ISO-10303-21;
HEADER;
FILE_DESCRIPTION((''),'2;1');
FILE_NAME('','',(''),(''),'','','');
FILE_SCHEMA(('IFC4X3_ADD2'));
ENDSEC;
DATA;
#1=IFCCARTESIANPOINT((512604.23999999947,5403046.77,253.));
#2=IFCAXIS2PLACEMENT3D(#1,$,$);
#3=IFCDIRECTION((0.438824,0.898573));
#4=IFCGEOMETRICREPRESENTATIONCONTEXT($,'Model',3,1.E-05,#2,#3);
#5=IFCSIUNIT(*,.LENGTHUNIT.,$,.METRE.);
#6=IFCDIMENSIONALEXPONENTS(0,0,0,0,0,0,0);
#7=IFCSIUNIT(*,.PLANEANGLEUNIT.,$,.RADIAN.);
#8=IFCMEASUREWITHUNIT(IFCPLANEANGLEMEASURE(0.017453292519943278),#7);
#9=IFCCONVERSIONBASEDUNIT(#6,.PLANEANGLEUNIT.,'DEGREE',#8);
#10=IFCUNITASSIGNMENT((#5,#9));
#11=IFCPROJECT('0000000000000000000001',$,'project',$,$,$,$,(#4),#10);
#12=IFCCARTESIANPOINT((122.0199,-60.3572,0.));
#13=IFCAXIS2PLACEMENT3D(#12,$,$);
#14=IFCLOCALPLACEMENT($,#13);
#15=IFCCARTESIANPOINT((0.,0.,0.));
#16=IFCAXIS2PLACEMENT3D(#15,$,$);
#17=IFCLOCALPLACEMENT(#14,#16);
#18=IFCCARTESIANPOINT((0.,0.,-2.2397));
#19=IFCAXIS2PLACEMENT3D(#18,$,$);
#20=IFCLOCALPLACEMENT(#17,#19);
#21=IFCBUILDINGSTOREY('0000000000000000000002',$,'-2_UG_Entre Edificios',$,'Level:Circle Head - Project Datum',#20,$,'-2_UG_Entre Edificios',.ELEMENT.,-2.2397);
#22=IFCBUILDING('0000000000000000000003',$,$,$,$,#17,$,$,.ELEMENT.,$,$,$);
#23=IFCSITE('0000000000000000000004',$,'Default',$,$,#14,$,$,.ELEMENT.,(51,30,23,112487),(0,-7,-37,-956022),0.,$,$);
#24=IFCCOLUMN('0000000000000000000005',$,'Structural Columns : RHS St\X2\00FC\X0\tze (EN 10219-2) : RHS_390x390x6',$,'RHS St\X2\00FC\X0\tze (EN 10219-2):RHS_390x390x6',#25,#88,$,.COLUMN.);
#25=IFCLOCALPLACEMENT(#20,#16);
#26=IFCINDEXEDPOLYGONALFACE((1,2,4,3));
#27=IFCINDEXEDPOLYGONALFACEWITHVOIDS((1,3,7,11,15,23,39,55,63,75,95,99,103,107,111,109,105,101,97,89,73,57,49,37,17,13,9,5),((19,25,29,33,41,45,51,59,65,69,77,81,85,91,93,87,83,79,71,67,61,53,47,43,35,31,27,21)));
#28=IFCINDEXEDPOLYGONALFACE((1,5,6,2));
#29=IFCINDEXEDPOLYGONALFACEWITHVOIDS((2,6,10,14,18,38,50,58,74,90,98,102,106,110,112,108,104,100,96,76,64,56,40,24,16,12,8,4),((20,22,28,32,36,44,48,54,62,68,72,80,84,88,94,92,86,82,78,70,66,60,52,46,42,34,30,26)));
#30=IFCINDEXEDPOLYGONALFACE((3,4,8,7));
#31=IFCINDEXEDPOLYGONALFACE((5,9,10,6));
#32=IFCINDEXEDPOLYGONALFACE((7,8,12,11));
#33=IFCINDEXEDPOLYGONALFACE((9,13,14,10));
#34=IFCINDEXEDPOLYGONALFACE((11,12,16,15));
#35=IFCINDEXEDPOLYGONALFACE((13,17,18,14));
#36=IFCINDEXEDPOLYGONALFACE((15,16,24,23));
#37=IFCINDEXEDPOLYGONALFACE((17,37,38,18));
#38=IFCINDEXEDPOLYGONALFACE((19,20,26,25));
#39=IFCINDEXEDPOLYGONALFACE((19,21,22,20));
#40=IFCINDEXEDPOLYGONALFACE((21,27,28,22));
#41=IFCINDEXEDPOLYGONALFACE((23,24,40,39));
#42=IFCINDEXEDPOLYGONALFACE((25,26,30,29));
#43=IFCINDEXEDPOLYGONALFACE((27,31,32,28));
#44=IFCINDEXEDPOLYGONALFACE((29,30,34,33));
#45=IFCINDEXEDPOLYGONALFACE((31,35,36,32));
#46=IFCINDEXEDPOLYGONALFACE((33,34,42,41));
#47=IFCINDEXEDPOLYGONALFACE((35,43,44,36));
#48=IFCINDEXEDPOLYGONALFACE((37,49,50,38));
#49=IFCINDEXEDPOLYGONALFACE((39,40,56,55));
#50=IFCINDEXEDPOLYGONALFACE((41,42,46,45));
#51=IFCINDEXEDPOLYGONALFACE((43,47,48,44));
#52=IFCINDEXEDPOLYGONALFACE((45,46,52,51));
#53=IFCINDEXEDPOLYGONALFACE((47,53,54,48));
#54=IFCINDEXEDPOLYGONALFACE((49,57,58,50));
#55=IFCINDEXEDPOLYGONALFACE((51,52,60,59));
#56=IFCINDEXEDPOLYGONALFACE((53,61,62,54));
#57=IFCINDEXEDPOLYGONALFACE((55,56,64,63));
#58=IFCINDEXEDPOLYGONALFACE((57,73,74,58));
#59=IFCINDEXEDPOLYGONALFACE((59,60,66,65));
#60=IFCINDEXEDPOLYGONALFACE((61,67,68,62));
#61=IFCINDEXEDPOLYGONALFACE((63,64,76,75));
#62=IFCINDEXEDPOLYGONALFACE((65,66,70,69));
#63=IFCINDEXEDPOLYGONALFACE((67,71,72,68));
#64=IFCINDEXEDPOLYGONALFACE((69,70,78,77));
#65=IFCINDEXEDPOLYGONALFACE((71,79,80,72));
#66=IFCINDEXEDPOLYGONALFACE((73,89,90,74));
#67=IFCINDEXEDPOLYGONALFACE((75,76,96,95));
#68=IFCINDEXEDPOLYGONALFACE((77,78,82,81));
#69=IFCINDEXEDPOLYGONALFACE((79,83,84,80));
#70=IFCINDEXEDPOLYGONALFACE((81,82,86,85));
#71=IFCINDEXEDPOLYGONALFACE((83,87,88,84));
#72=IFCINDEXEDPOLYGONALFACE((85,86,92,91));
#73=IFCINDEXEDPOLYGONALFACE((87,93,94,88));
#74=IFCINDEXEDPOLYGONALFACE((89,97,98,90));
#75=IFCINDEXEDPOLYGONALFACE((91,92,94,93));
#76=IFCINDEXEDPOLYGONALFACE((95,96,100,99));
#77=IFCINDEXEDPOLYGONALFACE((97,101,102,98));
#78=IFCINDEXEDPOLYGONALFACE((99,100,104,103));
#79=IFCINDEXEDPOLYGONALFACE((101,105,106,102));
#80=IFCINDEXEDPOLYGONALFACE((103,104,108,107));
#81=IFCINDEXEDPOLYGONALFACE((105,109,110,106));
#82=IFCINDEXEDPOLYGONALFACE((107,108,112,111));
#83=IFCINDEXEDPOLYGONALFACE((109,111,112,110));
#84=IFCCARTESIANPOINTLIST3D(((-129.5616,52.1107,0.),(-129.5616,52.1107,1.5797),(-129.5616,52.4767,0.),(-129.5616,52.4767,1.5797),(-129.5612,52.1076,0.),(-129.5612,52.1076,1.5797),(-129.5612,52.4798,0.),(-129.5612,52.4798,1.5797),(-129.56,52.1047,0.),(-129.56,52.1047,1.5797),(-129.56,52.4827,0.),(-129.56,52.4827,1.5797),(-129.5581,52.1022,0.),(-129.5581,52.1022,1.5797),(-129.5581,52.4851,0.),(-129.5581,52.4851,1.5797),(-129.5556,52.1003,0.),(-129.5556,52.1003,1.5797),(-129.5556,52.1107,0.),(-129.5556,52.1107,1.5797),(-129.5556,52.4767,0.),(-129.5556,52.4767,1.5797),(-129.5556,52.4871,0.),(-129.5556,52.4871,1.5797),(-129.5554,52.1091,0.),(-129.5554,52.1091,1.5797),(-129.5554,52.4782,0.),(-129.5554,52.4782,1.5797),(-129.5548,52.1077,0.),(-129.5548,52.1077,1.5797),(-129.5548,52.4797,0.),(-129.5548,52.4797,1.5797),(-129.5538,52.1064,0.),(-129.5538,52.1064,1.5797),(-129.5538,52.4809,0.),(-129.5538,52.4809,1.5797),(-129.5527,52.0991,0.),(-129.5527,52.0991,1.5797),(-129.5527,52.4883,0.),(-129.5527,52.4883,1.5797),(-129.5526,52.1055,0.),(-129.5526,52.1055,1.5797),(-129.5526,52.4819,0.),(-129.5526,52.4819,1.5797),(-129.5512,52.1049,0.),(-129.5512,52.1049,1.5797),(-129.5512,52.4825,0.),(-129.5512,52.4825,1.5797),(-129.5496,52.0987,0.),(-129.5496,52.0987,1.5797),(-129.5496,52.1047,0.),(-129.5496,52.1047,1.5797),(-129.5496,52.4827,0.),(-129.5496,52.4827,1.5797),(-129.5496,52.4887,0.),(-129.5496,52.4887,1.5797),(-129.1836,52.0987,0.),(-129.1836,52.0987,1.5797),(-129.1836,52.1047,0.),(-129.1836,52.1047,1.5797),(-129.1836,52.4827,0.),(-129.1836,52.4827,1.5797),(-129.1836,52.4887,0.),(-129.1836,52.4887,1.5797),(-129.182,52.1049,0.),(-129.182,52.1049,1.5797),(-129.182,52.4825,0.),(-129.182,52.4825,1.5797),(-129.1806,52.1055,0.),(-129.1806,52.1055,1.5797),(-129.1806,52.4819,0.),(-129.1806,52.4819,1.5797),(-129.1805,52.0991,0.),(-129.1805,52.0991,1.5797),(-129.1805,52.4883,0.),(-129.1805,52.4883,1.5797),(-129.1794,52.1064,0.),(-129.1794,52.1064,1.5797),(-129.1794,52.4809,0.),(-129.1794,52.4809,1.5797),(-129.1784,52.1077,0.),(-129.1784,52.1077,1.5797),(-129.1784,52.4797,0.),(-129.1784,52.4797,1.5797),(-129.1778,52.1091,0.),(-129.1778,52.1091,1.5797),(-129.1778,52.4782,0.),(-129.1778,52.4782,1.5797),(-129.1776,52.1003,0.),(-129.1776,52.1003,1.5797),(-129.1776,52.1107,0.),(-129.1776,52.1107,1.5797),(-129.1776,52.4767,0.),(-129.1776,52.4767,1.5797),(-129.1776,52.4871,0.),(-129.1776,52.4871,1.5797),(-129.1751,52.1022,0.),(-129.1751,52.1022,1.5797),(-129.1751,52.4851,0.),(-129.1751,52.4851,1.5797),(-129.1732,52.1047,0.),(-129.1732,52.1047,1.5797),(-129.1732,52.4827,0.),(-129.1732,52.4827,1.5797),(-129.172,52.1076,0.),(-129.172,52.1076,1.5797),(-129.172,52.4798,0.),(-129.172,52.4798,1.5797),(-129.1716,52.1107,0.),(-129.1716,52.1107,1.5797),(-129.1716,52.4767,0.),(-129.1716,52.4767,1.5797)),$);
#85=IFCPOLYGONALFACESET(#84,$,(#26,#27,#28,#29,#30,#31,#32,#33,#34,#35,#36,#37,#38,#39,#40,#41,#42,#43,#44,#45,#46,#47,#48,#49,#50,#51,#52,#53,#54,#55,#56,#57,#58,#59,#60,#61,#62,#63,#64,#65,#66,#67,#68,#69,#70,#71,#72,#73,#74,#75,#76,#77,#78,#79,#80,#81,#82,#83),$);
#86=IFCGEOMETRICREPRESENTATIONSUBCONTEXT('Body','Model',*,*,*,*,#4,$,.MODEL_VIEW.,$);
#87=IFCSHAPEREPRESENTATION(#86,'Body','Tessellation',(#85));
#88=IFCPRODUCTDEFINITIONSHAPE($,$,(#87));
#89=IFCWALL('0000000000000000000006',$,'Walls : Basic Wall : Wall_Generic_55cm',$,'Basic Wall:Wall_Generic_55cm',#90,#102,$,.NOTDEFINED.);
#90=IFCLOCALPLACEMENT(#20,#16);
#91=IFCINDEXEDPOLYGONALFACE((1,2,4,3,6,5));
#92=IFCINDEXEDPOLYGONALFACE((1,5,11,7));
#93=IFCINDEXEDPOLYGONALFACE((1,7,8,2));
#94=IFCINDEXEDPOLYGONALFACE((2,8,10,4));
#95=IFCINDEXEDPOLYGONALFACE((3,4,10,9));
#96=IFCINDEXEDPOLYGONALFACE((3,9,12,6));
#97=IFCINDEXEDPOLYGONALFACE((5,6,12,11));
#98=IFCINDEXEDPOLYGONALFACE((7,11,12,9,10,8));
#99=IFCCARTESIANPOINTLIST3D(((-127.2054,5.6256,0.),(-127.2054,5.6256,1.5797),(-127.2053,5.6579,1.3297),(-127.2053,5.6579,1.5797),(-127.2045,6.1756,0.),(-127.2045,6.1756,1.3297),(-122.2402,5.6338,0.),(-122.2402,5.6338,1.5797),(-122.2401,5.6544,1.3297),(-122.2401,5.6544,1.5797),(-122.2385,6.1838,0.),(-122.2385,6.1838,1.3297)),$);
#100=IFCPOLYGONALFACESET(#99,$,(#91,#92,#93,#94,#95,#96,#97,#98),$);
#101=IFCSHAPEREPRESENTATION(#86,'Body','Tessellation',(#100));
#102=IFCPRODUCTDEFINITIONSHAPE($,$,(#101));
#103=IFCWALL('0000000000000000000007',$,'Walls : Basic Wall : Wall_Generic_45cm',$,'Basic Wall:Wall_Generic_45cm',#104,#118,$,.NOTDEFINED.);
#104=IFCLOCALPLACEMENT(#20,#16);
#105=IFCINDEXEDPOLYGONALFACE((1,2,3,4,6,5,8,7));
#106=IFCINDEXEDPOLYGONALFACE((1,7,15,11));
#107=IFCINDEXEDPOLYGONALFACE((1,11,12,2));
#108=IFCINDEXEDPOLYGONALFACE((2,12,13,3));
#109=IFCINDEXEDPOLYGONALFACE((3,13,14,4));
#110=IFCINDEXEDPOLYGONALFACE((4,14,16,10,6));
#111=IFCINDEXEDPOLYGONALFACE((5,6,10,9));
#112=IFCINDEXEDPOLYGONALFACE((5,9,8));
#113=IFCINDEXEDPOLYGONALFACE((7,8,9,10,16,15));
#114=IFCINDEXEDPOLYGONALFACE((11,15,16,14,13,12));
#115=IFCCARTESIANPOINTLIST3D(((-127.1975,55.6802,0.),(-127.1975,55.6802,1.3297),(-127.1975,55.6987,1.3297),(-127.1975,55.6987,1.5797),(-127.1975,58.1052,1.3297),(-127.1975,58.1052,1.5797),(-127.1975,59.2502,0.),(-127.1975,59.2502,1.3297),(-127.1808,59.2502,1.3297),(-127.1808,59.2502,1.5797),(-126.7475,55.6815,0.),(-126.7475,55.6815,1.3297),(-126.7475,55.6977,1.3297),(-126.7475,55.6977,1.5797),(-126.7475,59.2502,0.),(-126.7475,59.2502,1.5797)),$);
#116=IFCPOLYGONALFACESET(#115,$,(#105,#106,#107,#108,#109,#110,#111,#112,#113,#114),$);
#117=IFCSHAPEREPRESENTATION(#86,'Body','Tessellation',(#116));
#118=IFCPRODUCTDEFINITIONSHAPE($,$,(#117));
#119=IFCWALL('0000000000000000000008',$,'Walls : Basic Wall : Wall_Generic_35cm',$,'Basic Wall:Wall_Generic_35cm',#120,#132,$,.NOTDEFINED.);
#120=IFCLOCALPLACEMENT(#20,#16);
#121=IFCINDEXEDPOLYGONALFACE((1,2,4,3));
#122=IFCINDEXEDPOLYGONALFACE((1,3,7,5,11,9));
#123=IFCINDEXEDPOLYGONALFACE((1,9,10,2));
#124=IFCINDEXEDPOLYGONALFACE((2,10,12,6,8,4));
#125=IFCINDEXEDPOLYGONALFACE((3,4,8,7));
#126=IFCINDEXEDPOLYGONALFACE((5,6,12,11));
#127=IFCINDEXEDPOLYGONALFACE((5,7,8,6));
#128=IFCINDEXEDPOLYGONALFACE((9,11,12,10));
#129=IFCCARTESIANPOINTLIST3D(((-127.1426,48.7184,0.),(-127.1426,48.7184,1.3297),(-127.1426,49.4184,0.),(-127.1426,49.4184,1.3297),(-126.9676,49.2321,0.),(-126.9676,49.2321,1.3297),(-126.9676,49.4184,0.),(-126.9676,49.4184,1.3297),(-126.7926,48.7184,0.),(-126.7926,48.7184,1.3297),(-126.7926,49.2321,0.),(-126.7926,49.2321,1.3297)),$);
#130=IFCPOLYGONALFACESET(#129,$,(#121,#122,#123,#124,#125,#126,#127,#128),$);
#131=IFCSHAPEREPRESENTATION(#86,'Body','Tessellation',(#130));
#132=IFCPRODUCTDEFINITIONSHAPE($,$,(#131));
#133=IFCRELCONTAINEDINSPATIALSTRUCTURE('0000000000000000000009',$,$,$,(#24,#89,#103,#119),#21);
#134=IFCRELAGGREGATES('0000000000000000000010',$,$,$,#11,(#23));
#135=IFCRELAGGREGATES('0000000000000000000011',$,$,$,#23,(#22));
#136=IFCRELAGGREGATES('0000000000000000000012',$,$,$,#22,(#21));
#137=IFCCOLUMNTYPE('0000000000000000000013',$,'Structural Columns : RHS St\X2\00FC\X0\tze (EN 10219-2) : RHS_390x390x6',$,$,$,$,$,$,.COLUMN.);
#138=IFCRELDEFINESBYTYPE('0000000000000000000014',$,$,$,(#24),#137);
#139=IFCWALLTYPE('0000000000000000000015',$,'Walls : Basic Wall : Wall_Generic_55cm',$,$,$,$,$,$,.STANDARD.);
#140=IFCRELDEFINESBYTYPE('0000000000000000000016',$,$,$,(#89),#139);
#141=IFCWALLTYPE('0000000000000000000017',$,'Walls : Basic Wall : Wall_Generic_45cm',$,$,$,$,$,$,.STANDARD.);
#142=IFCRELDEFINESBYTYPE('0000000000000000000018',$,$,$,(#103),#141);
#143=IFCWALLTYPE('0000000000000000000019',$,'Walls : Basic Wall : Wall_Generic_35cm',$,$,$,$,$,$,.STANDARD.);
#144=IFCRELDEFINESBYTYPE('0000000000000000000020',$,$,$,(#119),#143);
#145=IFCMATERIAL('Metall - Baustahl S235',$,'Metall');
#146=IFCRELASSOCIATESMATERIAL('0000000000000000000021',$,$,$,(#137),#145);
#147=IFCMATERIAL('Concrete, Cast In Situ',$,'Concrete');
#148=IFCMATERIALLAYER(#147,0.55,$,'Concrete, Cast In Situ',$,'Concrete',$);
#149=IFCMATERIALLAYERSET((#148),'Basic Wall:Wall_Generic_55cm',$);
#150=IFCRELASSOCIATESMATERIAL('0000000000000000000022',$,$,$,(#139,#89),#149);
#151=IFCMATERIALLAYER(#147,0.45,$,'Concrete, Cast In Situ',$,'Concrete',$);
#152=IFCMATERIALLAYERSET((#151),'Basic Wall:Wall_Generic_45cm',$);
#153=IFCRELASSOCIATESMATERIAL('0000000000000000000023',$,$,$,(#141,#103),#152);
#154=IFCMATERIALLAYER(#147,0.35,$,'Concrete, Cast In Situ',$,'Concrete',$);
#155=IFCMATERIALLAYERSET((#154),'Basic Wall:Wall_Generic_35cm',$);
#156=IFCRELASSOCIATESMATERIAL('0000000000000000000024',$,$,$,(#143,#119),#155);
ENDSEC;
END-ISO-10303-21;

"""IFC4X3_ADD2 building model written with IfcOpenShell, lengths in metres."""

from ifc_helpers import new_model, entity, si_unit, converted_unit, direction, frame, frame_2d, origin, place, context, subcontext, project, spatial, polyline, circle_curve, parameter, trimmed, segment, composite_curve, outline, extrude, clip, halfspace, bounded_halfspace, source, transform, mapped, material, layer, layer_set, material_profile, profile_set, type_object, type_shapes, element, save


model = new_model("IFC4X3_ADD2")

# Units and contexts
model_context = context("Model", 3, precision=1e-05, world=frame((512604.23999999947, 5403046.77, 253.0)), true_north=direction((0.438824, 0.898573)))
body_context = subcontext(model_context, "Body", "Model", "MODEL_VIEW")
ifc_project = project(units=[si_unit("LENGTHUNIT", "METRE"), converted_unit("PLANEANGLEUNIT", "DEGREE", entity("IfcPlaneAngleMeasure", 0.017453292519943278), si_unit("PLANEANGLEUNIT", "RADIAN"), dimensions=[0, 0, 0, 0, 0, 0, 0])], contexts=[model_context])

# Site, building, storey
site_placement = place(None, frame((122.0199, -60.3572, 0.0)))
site = spatial("IfcSite", under=ifc_project, at=site_placement, Name="Default", CompositionType="ELEMENT", RefLatitude=(51, 30, 23, 112487), RefLongitude=(0, -7, -37, -956022), RefElevation=0.0)
building_placement = place(site_placement, origin())
building = spatial("IfcBuilding", under=site, at=building_placement, CompositionType="ELEMENT")
storey_placement = place(building_placement, frame((0.0, 0.0, -2.2397)))
storey = spatial("IfcBuildingStorey", under=building, at=storey_placement, Name="-2_UG_Entre Edificios", ObjectType="Level:Circle Head - Project Datum", LongName="-2_UG_Entre Edificios", CompositionType="ELEMENT", Elevation=-2.2397)

# Column
ifc_material_1 = material(Name="Metall - Baustahl S235", Category="Metall")
ifc_material_profile_1 = material_profile(ifc_material_1, outline(composite_curve([segment(polyline([(-0.183, -0.195), (0.183, -0.195)]), True, "CONTINUOUS"), segment(trimmed(circle_curve(frame_2d((0.183, -0.183), x_axis=(-1.0, 0.0)), 0.012), [parameter(90.0)], [parameter(180.0)], True, "PARAMETER"), True, "CONTINUOUS"), segment(polyline([(0.195, -0.183), (0.195, 0.183)]), True, "CONTINUOUS"), segment(trimmed(circle_curve(frame_2d((0.183, 0.183), x_axis=(-1.0, 0.0)), 0.012), [parameter(180.0)], [parameter(270.0)], True, "PARAMETER"), True, "CONTINUOUS"), segment(polyline([(0.183, 0.195), (-0.183, 0.195)]), True, "CONTINUOUS"), segment(trimmed(circle_curve(frame_2d((-0.183, 0.183), x_axis=(-1.0, 0.0)), 0.012), [parameter(270.0)], [parameter(360.0)], True, "PARAMETER"), True, "CONTINUOUS"), segment(polyline([(-0.195, 0.183), (-0.195, -0.183)]), True, "CONTINUOUS"), segment(trimmed(circle_curve(frame_2d((-0.183, -0.183), x_axis=(-1.0, 0.0)), 0.012), [parameter(360.0)], [parameter(90.0)], True, "PARAMETER"), True, "CONTINUOUS")], self_intersect=False), holes=[composite_curve([segment(trimmed(circle_curve(frame_2d((-0.183, -0.183), x_axis=(-1.0, 0.0)), 0.006), [parameter(0.0)], [parameter(90.0)], True, "PARAMETER"), False, "CONTINUOUS"), segment(polyline([(-0.189, -0.183), (-0.189, 0.183)]), True, "CONTINUOUS"), segment(trimmed(circle_curve(frame_2d((-0.183, 0.183), x_axis=(-1.0, 0.0)), 0.006), [parameter(270.0)], [parameter(0.0)], True, "PARAMETER"), False, "CONTINUOUS"), segment(polyline([(-0.183, 0.189), (0.183, 0.189)]), True, "CONTINUOUS"), segment(trimmed(circle_curve(frame_2d((0.183, 0.183), x_axis=(-1.0, 0.0)), 0.006), [parameter(180.0)], [parameter(270.0)], True, "PARAMETER"), False, "CONTINUOUS"), segment(polyline([(0.189, 0.183), (0.189, -0.183)]), True, "CONTINUOUS"), segment(trimmed(circle_curve(frame_2d((0.183, -0.183), x_axis=(-1.0, 0.0)), 0.006), [parameter(90.0)], [parameter(180.0)], True, "PARAMETER"), False, "CONTINUOUS"), segment(polyline([(0.183, -0.189), (-0.183, -0.189)]), True, "CONTINUOUS")], self_intersect=False)]), Name="RHS_390x390x6")
ifc_profile_set_1 = profile_set([ifc_material_profile_1], Name="RHS_390x390x6")
column_type_1 = type_object("IfcColumnType", Name="Structural Columns : RHS Stütze (EN 10219-2) : RHS_390x390x6", PredefinedType="COLUMN", material=ifc_profile_set_1)
shared_shape_1 = source(origin(), body_context, "Body", "SweptSolid", [
    extrude(outline(composite_curve([segment(polyline([(-0.183, -0.195), (0.183, -0.195)]), True, "CONTINUOUS"), segment(trimmed(circle_curve(frame_2d((0.183, -0.183), x_axis=(-1.0, 0.0)), 0.012), [parameter(90.0)], [parameter(180.0)], True, "PARAMETER"), True, "CONTINUOUS"), segment(polyline([(0.195, -0.183), (0.195, 0.183)]), True, "CONTINUOUS"), segment(trimmed(circle_curve(frame_2d((0.183, 0.183), x_axis=(-1.0, 0.0)), 0.012), [parameter(180.0)], [parameter(270.0)], True, "PARAMETER"), True, "CONTINUOUS"), segment(polyline([(0.183, 0.195), (-0.183, 0.195)]), True, "CONTINUOUS"), segment(trimmed(circle_curve(frame_2d((-0.183, 0.183), x_axis=(-1.0, 0.0)), 0.012), [parameter(270.0)], [parameter(360.0)], True, "PARAMETER"), True, "CONTINUOUS"), segment(polyline([(-0.195, 0.183), (-0.195, -0.183)]), True, "CONTINUOUS"), segment(trimmed(circle_curve(frame_2d((-0.183, -0.183), x_axis=(-1.0, 0.0)), 0.012), [parameter(360.0)], [parameter(90.0)], True, "PARAMETER"), True, "CONTINUOUS")], self_intersect=False), holes=[composite_curve([segment(trimmed(circle_curve(frame_2d((-0.183, -0.183), x_axis=(-1.0, 0.0)), 0.006), [parameter(0.0)], [parameter(90.0)], True, "PARAMETER"), False, "CONTINUOUS"), segment(polyline([(-0.189, -0.183), (-0.189, 0.183)]), True, "CONTINUOUS"), segment(trimmed(circle_curve(frame_2d((-0.183, 0.183), x_axis=(-1.0, 0.0)), 0.006), [parameter(270.0)], [parameter(360.0)], True, "PARAMETER"), False, "CONTINUOUS"), segment(polyline([(-0.183, 0.189), (0.183, 0.189)]), True, "CONTINUOUS"), segment(trimmed(circle_curve(frame_2d((0.183, 0.183), x_axis=(-1.0, 0.0)), 0.006), [parameter(180.0)], [parameter(270.0)], True, "PARAMETER"), False, "CONTINUOUS"), segment(polyline([(0.189, 0.183), (0.189, -0.183)]), True, "CONTINUOUS"), segment(trimmed(circle_curve(frame_2d((0.183, -0.183), x_axis=(-1.0, 0.0)), 0.006), [parameter(90.0)], [parameter(180.0)], True, "PARAMETER"), False, "CONTINUOUS"), segment(polyline([(0.183, -0.189), (-0.183, -0.189)]), True, "CONTINUOUS")], self_intersect=False)]), frame((0.0, 0.0, -2.2397), z_axis=(0.0, 0.0, 1.0), x_axis=(-1.0, 0.0, 0.0)), (0.0, 0.0, 1.0), 1.5797),
])
type_shapes(column_type_1, [shared_shape_1])
column_1_placement = place(storey_placement, frame((-129.3666, 52.2937, 2.2397)))
element("IfcColumn", 1, at=column_1_placement, inside=storey, type_object=column_type_1, Name="Structural Columns : RHS Stütze (EN 10219-2) : RHS_390x390x6", ObjectType="RHS Stütze (EN 10219-2):RHS_390x390x6", PredefinedType="COLUMN", context=body_context, shape_type="MappedRepresentation", body=[
    mapped(shared_shape_1, transform((0.0, 0.0, 0.0), scale=1.0)),
])

# Walls
ifc_material_2 = material(Name="Concrete, Cast In Situ", Category="Concrete")
ifc_layer_1 = layer(ifc_material_2, 0.55, Name="Concrete, Cast In Situ", Category="Concrete")
ifc_layer_set_1 = layer_set([ifc_layer_1], Name="Basic Wall:Wall_Generic_55cm")
wall_type_1 = type_object("IfcWallType", Name="Walls : Basic Wall : Wall_Generic_55cm", PredefinedType="STANDARD", material=ifc_layer_set_1)
wall_1_placement = place(storey_placement, frame((-127.2058, 5.9006, 0.0), z_axis=(0.0, 0.0, 1.0), x_axis=(0.999999, 0.001649, 0.0)))
element("IfcWall", 2, at=wall_1_placement, inside=storey, type_object=wall_type_1, material=ifc_layer_set_1, Name="Walls : Basic Wall : Wall_Generic_55cm", ObjectType="Basic Wall:Wall_Generic_55cm", PredefinedType="NOTDEFINED", context=body_context, shape_type="Clipping", body=[
    clip(clip(extrude(outline(polyline([(4.9652, -0.275), (4.9678, 0.275), (0.3368, 0.275), (0.0017, 0.275), (0.0, -0.275), (4.9652, -0.275)])), origin(), (0.0, 0.0, 1.0), 1.5797), bounded_halfspace(frame((4.9653, -0.2545, 1.3297), z_axis=(0.0, 0.0, -1.0), x_axis=(0.999999, -0.001649, 0.0)), True, frame((4.9653, -0.2545, 1.3297)), polyline([(0.0, 0.0), (0.0025, 0.5295), (-0.4975, 0.5295), (-4.6285, 0.5295), (-4.9636, 0.5295), (-4.9652, 0.0117), (0.0, 0.0)]))), halfspace(frame((0.0, 0.0, -1.0603)), True)),
])
ifc_layer_2 = layer(ifc_material_2, 0.45, Name="Concrete, Cast In Situ", Category="Concrete")
ifc_layer_set_2 = layer_set([ifc_layer_2], Name="Basic Wall:Wall_Generic_45cm")
wall_type_2 = type_object("IfcWallType", Name="Walls : Basic Wall : Wall_Generic_45cm", PredefinedType="STANDARD", material=ifc_layer_set_2)
wall_2_placement = place(storey_placement, frame((-126.9725, 59.2502, 0.0), z_axis=(0.0, 0.0, 1.0), x_axis=(0.0, -1.0, 0.0)))
element("IfcWall", 3, at=wall_2_placement, inside=storey, type_object=wall_type_2, material=ifc_layer_set_2, Name="Walls : Basic Wall : Wall_Generic_45cm", ObjectType="Basic Wall:Wall_Generic_45cm", PredefinedType="NOTDEFINED", context=body_context, shape_type="Clipping", body=[
    clip(clip(clip(extrude(outline(polyline([(3.5701, -0.225), (3.5687, 0.225), (0.0, 0.225), (0.0, -0.225), (3.5701, -0.225)])), origin(), (0.0, 0.0, 1.0), 1.5797), bounded_halfspace(frame((0.0, -0.225, 1.3297), z_axis=(0.0, 0.0, -1.0), x_axis=(0.0, 1.0, 0.0)), True, frame((0.0, -0.225, 1.3297)), polyline([(0.0, 0.0), (1.145, 0.0), (0.0, 0.0166), (0.0, 0.0)]))), bounded_halfspace(frame((3.5516, -0.225, 1.3297), z_axis=(0.0, 0.0, -1.0), x_axis=(0.0, 1.0, 0.0)), True, frame((3.5516, -0.225, 1.3297)), polyline([(0.0, 0.0), (0.0185, 0.0), (0.0171, 0.45), (0.001, 0.45), (0.0004, 0.1991), (0.0, 0.0)]))), halfspace(frame((0.0, 0.0, -1.0603)), True)),
])
ifc_layer_3 = layer(ifc_material_2, 0.35, Name="Concrete, Cast In Situ", Category="Concrete")
ifc_layer_set_3 = layer_set([ifc_layer_3], Name="Basic Wall:Wall_Generic_35cm")
wall_type_3 = type_object("IfcWallType", Name="Walls : Basic Wall : Wall_Generic_35cm", PredefinedType="STANDARD", material=ifc_layer_set_3)
wall_3_placement = place(storey_placement, frame((-126.9676, 49.4184, 0.0), z_axis=(0.0, 0.0, 1.0), x_axis=(0.0, -1.0, 0.0)))
element("IfcWall", 4, at=wall_3_placement, inside=storey, type_object=wall_type_3, material=ifc_layer_set_3, Name="Walls : Basic Wall : Wall_Generic_35cm", ObjectType="Basic Wall:Wall_Generic_35cm", PredefinedType="NOTDEFINED", context=body_context, shape_type="Clipping", body=[
    clip(clip(clip(clip(extrude(outline(polyline([(0.7, -0.175), (0.7, 0.175), (0.4664, 0.175), (0.1864, 0.175), (0.1864, 0.0), (0.0, 0.0), (0.0, -0.175), (0.4, -0.175), (0.7, -0.175)])), origin(), (0.0, 0.0, 1.0), 1.3297), bounded_halfspace(frame((0.0, -0.175, 1.3297), z_axis=(0.0, 0.0, -1.0), x_axis=(0.0, 1.0, 0.0)), True, frame((0.0, -0.175, 1.3297)), polyline([(0.0, 0.0), (0.4, 0.0), (0.7, 0.0), (0.7, 0.35), (0.4664, 0.35), (0.1864, 0.35), (0.1864, 0.175), (0.0, 0.175), (0.0, 0.0)]))), bounded_halfspace(frame((0.1864, 0.0, 1.3297), z_axis=(0.0, -1.0, 0.0), x_axis=(1.0, 0.0, 0.0)), True, frame((0.1864, 0.0, 1.3297), z_axis=(0.0, -1.0, 0.0), x_axis=(1.0, 0.0, 0.0)), polyline([(0.0, 0.0), (-0.1864, 0.0), (-0.1864, -2.39), (0.0, -2.39), (0.0, 0.0)]))), bounded_halfspace(frame((0.1864, 0.0, -1.0603), z_axis=(1.0, 0.0, 0.0), x_axis=(0.0, 1.0, 0.0)), True, frame((0.1864, 0.0, -1.0603), z_axis=(1.0, 0.0, 0.0), x_axis=(0.0, 1.0, 0.0)), polyline([(0.0, 0.0), (0.175, 0.0), (0.175, 2.39), (0.0, 2.39), (0.0, 0.0)]))), halfspace(frame((0.0, 0.0, -1.0603)), True)),
])

save(model, "model.ifc")
